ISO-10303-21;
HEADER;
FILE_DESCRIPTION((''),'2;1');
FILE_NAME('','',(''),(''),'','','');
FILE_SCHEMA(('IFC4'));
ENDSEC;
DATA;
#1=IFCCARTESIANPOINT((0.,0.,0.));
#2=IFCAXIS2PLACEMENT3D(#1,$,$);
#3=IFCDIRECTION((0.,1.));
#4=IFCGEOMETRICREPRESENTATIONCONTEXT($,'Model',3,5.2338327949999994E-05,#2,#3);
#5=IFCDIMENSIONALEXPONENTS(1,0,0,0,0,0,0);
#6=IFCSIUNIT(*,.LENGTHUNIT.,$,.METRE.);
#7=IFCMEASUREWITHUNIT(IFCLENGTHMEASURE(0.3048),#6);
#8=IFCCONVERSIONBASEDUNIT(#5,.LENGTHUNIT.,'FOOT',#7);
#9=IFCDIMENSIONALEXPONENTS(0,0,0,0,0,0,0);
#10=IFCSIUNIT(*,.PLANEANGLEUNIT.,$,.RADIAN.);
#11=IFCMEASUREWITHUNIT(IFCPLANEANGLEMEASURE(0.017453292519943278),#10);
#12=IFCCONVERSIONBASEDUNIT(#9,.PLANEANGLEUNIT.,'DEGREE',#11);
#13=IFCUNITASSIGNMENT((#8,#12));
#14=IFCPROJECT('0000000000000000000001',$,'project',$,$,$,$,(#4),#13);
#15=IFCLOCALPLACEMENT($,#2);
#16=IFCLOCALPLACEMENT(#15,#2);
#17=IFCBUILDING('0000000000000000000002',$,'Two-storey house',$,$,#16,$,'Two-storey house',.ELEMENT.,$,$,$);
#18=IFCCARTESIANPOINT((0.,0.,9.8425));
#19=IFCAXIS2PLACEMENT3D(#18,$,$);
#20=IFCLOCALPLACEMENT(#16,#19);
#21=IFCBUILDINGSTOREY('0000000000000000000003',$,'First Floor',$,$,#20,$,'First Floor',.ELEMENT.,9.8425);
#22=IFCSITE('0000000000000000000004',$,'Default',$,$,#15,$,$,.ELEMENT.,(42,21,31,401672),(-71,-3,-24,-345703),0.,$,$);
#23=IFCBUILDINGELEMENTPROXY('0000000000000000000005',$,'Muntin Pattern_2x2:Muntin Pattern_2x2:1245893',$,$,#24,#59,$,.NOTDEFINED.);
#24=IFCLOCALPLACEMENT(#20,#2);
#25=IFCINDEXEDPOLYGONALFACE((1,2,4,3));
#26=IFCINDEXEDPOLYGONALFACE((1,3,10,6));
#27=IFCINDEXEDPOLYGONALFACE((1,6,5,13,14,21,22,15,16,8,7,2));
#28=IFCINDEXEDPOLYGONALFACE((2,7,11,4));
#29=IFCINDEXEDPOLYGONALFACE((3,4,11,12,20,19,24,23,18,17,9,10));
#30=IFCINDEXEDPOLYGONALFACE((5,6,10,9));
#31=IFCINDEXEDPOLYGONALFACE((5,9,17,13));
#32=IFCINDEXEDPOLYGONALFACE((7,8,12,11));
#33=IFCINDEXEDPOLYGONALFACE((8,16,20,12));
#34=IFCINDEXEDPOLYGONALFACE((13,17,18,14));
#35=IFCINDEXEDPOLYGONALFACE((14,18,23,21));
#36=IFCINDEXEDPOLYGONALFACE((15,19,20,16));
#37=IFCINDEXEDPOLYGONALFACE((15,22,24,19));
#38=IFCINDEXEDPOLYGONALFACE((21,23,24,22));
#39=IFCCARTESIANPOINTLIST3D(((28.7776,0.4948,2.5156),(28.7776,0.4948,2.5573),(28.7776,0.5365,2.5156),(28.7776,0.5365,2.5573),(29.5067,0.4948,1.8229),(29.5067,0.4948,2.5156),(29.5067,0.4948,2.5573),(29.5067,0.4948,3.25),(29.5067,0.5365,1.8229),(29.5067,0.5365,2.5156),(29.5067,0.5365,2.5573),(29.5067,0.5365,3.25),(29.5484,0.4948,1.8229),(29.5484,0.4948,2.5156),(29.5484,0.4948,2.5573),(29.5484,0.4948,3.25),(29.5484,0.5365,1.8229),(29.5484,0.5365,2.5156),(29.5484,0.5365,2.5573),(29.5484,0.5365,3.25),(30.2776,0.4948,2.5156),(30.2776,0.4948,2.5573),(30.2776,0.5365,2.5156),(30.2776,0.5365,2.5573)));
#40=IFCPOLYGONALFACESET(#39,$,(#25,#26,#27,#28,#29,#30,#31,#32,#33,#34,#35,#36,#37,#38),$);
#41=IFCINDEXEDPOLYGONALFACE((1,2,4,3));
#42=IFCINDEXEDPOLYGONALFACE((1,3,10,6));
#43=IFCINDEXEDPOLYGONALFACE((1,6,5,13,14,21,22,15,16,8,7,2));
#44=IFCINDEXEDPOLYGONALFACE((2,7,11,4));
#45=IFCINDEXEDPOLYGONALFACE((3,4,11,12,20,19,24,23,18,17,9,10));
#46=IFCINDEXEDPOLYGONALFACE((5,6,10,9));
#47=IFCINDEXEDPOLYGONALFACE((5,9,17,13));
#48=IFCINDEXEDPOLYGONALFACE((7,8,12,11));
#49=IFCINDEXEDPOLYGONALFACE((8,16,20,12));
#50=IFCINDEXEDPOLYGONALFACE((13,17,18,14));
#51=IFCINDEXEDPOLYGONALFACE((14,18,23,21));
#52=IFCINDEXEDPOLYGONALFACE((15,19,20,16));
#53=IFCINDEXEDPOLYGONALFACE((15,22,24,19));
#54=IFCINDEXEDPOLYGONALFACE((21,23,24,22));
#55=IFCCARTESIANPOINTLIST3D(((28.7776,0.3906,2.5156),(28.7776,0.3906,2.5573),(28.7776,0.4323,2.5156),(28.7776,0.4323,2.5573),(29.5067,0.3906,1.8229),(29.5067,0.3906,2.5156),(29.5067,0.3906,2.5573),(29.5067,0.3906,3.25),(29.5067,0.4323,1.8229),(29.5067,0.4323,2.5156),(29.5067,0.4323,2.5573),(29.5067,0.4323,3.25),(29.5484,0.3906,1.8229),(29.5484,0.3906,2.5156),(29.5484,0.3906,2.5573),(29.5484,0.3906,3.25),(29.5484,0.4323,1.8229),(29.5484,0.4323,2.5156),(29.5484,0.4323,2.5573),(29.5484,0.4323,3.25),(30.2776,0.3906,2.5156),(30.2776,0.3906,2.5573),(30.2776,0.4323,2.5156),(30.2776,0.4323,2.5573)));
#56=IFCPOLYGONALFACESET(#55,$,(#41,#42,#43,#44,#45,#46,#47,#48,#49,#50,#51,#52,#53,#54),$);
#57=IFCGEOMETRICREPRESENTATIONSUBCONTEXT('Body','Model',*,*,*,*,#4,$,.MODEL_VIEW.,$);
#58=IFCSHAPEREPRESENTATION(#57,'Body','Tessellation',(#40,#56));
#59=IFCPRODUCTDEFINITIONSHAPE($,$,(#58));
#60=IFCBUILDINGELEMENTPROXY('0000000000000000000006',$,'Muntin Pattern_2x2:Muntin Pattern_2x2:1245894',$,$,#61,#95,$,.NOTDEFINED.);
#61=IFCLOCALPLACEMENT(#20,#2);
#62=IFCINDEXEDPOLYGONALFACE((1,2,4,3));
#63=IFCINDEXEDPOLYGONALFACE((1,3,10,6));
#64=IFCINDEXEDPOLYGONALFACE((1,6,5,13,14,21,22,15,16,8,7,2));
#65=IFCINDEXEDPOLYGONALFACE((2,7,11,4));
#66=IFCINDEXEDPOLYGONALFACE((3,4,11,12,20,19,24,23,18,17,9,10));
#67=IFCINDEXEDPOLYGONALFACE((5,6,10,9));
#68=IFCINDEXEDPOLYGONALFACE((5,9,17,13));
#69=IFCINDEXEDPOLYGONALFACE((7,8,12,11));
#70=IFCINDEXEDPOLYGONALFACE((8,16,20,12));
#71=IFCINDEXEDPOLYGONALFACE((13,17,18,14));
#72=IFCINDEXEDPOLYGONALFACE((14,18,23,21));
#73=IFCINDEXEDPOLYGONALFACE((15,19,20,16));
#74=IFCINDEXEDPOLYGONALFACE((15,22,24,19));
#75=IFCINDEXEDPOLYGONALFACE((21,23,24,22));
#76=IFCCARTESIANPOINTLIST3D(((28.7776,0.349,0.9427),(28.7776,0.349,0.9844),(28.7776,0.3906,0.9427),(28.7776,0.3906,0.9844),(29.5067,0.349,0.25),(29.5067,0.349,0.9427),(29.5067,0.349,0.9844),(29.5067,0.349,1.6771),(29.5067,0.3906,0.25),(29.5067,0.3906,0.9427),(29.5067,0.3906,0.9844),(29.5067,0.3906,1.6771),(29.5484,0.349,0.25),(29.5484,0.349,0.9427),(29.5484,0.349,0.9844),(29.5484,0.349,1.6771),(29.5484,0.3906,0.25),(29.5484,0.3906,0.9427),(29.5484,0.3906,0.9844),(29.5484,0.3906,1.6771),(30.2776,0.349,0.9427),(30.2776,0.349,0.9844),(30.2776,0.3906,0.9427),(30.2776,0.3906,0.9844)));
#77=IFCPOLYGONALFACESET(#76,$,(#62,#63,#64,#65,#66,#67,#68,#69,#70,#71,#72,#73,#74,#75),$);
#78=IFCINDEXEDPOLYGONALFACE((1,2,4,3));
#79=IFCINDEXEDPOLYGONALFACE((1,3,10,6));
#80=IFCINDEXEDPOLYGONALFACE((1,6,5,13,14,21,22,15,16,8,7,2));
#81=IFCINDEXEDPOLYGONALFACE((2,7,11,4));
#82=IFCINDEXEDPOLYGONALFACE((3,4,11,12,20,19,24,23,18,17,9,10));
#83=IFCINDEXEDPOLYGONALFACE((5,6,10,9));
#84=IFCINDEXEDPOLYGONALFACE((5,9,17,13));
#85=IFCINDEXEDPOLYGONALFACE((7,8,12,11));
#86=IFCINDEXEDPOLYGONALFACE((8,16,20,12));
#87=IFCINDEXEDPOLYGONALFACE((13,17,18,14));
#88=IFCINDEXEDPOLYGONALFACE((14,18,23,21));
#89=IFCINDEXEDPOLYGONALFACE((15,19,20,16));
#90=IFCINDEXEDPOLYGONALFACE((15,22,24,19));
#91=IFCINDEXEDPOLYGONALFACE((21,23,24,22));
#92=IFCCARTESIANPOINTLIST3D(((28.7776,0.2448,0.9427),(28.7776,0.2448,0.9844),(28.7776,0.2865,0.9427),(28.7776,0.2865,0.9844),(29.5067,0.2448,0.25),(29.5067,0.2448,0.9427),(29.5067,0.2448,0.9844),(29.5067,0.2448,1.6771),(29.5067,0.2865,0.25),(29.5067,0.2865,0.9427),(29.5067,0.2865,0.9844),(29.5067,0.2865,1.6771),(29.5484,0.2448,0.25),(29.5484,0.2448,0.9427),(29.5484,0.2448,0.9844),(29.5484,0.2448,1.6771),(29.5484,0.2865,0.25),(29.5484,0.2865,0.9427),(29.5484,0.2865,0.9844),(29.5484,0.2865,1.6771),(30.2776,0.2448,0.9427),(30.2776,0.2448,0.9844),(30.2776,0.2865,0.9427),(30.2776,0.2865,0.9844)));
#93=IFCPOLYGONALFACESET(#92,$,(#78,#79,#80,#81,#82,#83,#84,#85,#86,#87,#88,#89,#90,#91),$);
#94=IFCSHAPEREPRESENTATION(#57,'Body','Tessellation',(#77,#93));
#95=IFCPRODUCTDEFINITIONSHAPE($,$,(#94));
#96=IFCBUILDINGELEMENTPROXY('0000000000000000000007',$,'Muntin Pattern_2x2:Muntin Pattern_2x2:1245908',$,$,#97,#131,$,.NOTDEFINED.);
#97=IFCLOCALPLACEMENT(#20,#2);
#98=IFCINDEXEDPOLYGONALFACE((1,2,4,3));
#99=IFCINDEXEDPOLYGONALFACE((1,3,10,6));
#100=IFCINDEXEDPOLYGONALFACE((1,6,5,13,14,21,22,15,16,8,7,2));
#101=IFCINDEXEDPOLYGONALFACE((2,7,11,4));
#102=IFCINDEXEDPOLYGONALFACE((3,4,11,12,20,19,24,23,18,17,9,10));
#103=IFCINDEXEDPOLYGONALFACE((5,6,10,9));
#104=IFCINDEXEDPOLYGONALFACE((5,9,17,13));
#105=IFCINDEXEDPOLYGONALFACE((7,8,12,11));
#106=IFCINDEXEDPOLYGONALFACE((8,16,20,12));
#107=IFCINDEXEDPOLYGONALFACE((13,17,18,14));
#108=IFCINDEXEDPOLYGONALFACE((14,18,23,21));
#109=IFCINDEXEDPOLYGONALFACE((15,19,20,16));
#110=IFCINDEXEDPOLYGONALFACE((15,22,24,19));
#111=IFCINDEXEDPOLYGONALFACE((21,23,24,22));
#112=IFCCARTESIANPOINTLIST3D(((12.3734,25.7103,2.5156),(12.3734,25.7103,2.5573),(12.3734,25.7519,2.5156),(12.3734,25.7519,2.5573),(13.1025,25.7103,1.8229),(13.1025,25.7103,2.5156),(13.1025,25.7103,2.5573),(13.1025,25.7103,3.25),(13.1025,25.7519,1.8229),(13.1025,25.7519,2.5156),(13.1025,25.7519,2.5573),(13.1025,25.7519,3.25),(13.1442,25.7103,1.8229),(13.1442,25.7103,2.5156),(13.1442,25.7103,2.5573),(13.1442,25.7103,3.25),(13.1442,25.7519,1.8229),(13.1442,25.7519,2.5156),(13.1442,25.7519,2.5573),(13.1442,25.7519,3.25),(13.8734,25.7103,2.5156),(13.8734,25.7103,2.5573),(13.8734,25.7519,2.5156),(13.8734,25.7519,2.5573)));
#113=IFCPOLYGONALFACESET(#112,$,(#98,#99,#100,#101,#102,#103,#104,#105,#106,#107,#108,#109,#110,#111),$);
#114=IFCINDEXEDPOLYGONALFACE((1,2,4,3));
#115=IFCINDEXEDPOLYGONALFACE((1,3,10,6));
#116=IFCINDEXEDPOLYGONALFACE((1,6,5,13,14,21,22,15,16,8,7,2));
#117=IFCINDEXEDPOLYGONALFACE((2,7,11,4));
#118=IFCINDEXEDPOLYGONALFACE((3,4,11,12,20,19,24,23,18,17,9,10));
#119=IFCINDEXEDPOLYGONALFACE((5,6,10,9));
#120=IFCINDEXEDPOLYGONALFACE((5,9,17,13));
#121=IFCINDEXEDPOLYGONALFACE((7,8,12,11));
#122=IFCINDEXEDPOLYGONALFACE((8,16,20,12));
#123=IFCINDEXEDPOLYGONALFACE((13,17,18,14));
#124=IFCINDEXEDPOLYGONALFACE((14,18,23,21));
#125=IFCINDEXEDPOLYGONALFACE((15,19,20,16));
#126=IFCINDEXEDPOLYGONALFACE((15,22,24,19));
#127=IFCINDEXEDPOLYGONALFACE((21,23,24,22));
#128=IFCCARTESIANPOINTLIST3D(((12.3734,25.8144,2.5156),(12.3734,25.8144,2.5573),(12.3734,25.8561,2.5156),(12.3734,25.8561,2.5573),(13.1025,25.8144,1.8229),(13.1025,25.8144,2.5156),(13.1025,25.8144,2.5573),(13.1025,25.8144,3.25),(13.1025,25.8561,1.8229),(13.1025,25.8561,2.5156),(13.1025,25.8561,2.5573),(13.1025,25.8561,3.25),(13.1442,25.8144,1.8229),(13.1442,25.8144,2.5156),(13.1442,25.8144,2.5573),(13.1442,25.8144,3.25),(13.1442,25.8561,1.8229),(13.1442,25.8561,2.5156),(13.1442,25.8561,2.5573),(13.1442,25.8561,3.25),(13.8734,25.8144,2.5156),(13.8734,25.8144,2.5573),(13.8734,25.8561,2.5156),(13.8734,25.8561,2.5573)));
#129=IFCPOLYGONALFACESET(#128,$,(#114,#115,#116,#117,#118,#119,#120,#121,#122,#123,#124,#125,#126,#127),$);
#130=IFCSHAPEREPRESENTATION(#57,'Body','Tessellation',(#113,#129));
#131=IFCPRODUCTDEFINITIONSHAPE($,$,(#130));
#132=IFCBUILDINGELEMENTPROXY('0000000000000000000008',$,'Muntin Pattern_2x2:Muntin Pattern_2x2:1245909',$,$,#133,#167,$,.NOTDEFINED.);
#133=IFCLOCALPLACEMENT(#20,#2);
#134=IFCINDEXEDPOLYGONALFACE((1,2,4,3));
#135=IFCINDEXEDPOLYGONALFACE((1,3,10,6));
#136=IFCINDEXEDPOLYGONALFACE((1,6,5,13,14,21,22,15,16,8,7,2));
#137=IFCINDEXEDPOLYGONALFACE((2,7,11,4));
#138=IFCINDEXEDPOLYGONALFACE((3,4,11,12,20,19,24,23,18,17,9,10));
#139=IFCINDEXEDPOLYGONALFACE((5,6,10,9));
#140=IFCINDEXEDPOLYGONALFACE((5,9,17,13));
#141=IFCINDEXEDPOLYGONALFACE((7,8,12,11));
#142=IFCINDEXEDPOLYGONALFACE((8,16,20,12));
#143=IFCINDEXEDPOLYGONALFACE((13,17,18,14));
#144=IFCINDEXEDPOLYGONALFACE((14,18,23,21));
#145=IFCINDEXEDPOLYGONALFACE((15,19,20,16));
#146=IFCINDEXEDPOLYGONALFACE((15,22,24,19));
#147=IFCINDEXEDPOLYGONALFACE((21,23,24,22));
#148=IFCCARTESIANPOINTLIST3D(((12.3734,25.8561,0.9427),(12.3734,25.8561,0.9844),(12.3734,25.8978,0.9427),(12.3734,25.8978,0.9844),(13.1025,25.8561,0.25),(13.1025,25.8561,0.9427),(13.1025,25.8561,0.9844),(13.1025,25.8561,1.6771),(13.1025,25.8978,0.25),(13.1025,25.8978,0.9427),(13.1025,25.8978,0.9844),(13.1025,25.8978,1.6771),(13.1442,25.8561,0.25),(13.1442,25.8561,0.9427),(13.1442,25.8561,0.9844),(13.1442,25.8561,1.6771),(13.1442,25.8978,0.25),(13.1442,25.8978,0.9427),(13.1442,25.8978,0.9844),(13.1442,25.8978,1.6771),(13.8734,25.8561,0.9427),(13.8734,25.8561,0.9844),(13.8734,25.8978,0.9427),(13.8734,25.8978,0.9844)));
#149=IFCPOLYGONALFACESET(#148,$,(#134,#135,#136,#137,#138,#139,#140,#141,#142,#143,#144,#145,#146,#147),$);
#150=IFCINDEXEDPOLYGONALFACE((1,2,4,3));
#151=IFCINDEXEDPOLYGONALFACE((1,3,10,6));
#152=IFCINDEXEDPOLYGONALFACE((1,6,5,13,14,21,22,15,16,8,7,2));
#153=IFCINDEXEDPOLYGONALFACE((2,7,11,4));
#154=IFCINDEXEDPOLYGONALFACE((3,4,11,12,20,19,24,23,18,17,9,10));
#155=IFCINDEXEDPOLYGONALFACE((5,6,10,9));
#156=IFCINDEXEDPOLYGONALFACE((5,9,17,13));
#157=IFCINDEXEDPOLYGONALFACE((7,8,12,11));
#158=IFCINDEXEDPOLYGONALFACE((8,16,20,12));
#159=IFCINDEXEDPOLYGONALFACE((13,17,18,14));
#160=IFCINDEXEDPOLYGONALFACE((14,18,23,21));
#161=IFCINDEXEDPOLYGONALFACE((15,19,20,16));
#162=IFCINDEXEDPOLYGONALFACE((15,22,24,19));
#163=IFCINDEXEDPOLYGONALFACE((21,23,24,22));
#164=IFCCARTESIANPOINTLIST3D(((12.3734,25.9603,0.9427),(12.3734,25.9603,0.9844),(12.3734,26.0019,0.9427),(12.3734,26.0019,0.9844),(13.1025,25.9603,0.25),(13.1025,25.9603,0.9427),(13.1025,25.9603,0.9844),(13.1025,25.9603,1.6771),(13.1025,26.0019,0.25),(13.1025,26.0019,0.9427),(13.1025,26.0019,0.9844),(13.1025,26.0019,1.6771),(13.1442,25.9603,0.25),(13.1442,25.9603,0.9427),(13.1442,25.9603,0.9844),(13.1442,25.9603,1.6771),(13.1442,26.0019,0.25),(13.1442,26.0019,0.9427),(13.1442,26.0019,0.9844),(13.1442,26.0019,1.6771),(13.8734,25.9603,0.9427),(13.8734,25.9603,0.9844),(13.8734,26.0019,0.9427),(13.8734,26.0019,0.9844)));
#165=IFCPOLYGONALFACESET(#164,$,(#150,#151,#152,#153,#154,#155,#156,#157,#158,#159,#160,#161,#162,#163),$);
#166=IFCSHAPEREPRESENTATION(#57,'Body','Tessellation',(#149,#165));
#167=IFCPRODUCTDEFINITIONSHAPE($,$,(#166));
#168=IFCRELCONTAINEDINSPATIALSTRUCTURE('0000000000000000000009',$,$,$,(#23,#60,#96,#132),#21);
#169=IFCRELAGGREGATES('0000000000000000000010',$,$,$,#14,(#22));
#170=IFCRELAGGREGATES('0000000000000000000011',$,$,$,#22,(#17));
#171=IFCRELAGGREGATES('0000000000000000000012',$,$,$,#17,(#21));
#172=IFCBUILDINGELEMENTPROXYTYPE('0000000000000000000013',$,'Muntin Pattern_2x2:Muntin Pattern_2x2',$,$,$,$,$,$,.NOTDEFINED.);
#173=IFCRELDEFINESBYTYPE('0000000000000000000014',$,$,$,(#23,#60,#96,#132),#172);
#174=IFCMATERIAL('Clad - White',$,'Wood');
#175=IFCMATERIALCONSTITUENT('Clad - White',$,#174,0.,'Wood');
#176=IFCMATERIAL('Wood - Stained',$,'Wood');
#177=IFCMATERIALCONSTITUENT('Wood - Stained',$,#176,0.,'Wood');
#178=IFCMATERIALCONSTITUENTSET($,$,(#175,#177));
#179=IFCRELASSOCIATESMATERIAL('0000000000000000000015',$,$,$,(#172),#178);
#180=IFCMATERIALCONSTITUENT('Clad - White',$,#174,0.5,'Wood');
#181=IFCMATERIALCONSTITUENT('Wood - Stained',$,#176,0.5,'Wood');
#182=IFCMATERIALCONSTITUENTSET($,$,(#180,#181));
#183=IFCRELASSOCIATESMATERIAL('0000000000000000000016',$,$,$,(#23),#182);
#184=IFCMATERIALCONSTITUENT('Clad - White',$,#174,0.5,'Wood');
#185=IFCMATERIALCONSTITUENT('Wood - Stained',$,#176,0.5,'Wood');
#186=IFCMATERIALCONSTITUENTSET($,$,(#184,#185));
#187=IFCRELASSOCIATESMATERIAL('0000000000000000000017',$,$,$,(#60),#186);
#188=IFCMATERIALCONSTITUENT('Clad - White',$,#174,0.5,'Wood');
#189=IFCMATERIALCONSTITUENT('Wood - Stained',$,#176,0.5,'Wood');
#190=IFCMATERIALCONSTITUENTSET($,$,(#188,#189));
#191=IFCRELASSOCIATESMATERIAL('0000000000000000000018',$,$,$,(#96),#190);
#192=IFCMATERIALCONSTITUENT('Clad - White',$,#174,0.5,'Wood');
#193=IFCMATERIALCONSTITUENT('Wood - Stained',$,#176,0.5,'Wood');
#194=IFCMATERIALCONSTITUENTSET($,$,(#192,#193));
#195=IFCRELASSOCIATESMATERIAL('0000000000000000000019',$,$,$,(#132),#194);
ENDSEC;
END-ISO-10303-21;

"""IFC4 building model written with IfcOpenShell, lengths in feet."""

from ifc_helpers import new_model, entity, si_unit, converted_unit, direction, frame, origin, place, context, subcontext, project, spatial, indexed_curve, outline, extrude, source, transform, mapped, material, constituent, constituent_set, type_object, type_shapes, element, save


model = new_model("IFC4")

# Units and contexts
model_context = context("Model", 3, precision=5.2338327949999994e-05, world=origin(), true_north=direction((0.0, 1.0)))
body_context = subcontext(model_context, "Body", "Model", "MODEL_VIEW")
ifc_project = project(units=[converted_unit("LENGTHUNIT", "FOOT", entity("IfcLengthMeasure", 0.3048), si_unit("LENGTHUNIT", "METRE"), dimensions=[1, 0, 0, 0, 0, 0, 0]), converted_unit("PLANEANGLEUNIT", "DEGREE", entity("IfcPlaneAngleMeasure", 0.017453292519943278), si_unit("PLANEANGLEUNIT", "RADIAN"), dimensions=[0, 0, 0, 0, 0, 0, 0])], contexts=[model_context])

# Site, building, storey
site_placement = place(None, origin())
site = spatial("IfcSite", under=ifc_project, at=site_placement, Name="Default", CompositionType="ELEMENT", RefLatitude=(42, 21, 31, 401672), RefLongitude=(-71, -3, -24, -345703), RefElevation=0.0)
building_placement = place(site_placement, origin())
building = spatial("IfcBuilding", under=site, at=building_placement, Name="Two-storey house", LongName="Two-storey house", CompositionType="ELEMENT")
storey_placement = place(building_placement, frame((0.0, 0.0, 9.8425)))
storey = spatial("IfcBuildingStorey", under=building, at=storey_placement, Name="First Floor", LongName="First Floor", CompositionType="ELEMENT", Elevation=9.8425)

# Shared definitions
ifc_material_1 = material(Name="Wood - Stained", Category="Wood")

# Building element proxies
ifc_material_2 = material(Name="Clad - White", Category="Wood")
ifc_constituent_1 = constituent(ifc_material_2, Name="Clad - White", Category="Wood", fraction=0.5)
ifc_constituent_2 = constituent(ifc_material_1, Name="Wood - Stained", Category="Wood", fraction=0.5)
ifc_constituent_set_1 = constituent_set(constituents=[ifc_constituent_1, ifc_constituent_2])
ifc_constituent_3 = constituent(ifc_material_2, Name="Clad - White", Category="Wood", fraction=0.0)
ifc_constituent_4 = constituent(ifc_material_1, Name="Wood - Stained", Category="Wood", fraction=0.0)
ifc_constituent_set_2 = constituent_set(constituents=[ifc_constituent_3, ifc_constituent_4])
building_element_proxy_type_1 = type_object("IfcBuildingElementProxyType", Name="Muntin Pattern_2x2:Muntin Pattern_2x2", PredefinedType="NOTDEFINED", material=ifc_constituent_set_2)
shared_shape_1 = source(origin(), body_context, "Body", "SweptSolid", [
    extrude(outline(indexed_curve([(0.0208, -0.0208), (0.7135, -0.0208), (0.7135, 0.0208), (0.0208, 0.0208), (0.0208, 0.75), (-0.0208, 0.75), (-0.0208, 0.0208), (-0.7135, 0.0208), (-0.7135, -0.0208), (-0.0208, -0.0208), (-0.0208, -0.75), (0.0208, -0.75), (0.0208, -0.0208)], self_intersect=False)), frame((0.0, 0.0312, 0.7135), z_axis=(0.0, 1.0, 0.0), x_axis=(0.0, 0.0, 1.0)), (0.0, 0.0, 1.0), 0.0417),
    extrude(outline(indexed_curve([(0.0208, -0.0208), (0.7135, -0.0208), (0.7135, 0.0208), (0.0208, 0.0208), (0.0208, 0.75), (-0.0208, 0.75), (-0.0208, 0.0208), (-0.7135, 0.0208), (-0.7135, -0.0208), (-0.0208, -0.0208), (-0.0208, -0.75), (0.0208, -0.75), (0.0208, -0.0208)], self_intersect=False)), frame((0.0, -0.0729, 0.7135), z_axis=(0.0, 1.0, 0.0), x_axis=(0.0, 0.0, 1.0)), (0.0, 0.0, 1.0), 0.0417),
])
type_shapes(building_element_proxy_type_1, [shared_shape_1])
proxy_1_placement = place(storey_placement, frame((29.5276, 0.4635, 1.8229)))
element("IfcBuildingElementProxy", 1, at=proxy_1_placement, inside=storey, type_object=building_element_proxy_type_1, material=ifc_constituent_set_1, Name="Muntin Pattern_2x2:Muntin Pattern_2x2:1245893", PredefinedType="NOTDEFINED", context=body_context, shape_type="MappedRepresentation", body=[
    mapped(shared_shape_1, transform((0.0, 0.0, 0.0), scale=1.0)),
])
ifc_constituent_5 = constituent(ifc_material_2, Name="Clad - White", Category="Wood", fraction=0.5)
ifc_constituent_6 = constituent(ifc_material_1, Name="Wood - Stained", Category="Wood", fraction=0.5)
ifc_constituent_set_3 = constituent_set(constituents=[ifc_constituent_5, ifc_constituent_6])
proxy_2_placement = place(storey_placement, frame((29.5276, 0.3177, 0.25)))
element("IfcBuildingElementProxy", 2, at=proxy_2_placement, inside=storey, type_object=building_element_proxy_type_1, material=ifc_constituent_set_3, Name="Muntin Pattern_2x2:Muntin Pattern_2x2:1245894", PredefinedType="NOTDEFINED", context=body_context, shape_type="MappedRepresentation", body=[
    mapped(shared_shape_1, transform((0.0, 0.0, 0.0), scale=1.0)),
])
ifc_constituent_7 = constituent(ifc_material_2, Name="Clad - White", Category="Wood", fraction=0.5)
ifc_constituent_8 = constituent(ifc_material_1, Name="Wood - Stained", Category="Wood", fraction=0.5)
ifc_constituent_set_4 = constituent_set(constituents=[ifc_constituent_7, ifc_constituent_8])
proxy_3_placement = place(storey_placement, frame((13.1234, 25.7832, 1.8229), z_axis=(0.0, 0.0, 1.0), x_axis=(-1.0, 0.0, 0.0)))
element("IfcBuildingElementProxy", 3, at=proxy_3_placement, inside=storey, type_object=building_element_proxy_type_1, material=ifc_constituent_set_4, Name="Muntin Pattern_2x2:Muntin Pattern_2x2:1245908", PredefinedType="NOTDEFINED", context=body_context, shape_type="MappedRepresentation", body=[
    mapped(shared_shape_1, transform((0.0, 0.0, 0.0), scale=1.0)),
])
ifc_constituent_9 = constituent(ifc_material_2, Name="Clad - White", Category="Wood", fraction=0.5)
ifc_constituent_10 = constituent(ifc_material_1, Name="Wood - Stained", Category="Wood", fraction=0.5)
ifc_constituent_set_5 = constituent_set(constituents=[ifc_constituent_9, ifc_constituent_10])
proxy_4_placement = place(storey_placement, frame((13.1234, 25.929, 0.25), z_axis=(0.0, 0.0, 1.0), x_axis=(-1.0, 0.0, 0.0)))
element("IfcBuildingElementProxy", 4, at=proxy_4_placement, inside=storey, type_object=building_element_proxy_type_1, material=ifc_constituent_set_5, Name="Muntin Pattern_2x2:Muntin Pattern_2x2:1245909", PredefinedType="NOTDEFINED", context=body_context, shape_type="MappedRepresentation", body=[
    mapped(shared_shape_1, transform((0.0, 0.0, 0.0), scale=1.0)),
])

save(model, "model.ifc")
